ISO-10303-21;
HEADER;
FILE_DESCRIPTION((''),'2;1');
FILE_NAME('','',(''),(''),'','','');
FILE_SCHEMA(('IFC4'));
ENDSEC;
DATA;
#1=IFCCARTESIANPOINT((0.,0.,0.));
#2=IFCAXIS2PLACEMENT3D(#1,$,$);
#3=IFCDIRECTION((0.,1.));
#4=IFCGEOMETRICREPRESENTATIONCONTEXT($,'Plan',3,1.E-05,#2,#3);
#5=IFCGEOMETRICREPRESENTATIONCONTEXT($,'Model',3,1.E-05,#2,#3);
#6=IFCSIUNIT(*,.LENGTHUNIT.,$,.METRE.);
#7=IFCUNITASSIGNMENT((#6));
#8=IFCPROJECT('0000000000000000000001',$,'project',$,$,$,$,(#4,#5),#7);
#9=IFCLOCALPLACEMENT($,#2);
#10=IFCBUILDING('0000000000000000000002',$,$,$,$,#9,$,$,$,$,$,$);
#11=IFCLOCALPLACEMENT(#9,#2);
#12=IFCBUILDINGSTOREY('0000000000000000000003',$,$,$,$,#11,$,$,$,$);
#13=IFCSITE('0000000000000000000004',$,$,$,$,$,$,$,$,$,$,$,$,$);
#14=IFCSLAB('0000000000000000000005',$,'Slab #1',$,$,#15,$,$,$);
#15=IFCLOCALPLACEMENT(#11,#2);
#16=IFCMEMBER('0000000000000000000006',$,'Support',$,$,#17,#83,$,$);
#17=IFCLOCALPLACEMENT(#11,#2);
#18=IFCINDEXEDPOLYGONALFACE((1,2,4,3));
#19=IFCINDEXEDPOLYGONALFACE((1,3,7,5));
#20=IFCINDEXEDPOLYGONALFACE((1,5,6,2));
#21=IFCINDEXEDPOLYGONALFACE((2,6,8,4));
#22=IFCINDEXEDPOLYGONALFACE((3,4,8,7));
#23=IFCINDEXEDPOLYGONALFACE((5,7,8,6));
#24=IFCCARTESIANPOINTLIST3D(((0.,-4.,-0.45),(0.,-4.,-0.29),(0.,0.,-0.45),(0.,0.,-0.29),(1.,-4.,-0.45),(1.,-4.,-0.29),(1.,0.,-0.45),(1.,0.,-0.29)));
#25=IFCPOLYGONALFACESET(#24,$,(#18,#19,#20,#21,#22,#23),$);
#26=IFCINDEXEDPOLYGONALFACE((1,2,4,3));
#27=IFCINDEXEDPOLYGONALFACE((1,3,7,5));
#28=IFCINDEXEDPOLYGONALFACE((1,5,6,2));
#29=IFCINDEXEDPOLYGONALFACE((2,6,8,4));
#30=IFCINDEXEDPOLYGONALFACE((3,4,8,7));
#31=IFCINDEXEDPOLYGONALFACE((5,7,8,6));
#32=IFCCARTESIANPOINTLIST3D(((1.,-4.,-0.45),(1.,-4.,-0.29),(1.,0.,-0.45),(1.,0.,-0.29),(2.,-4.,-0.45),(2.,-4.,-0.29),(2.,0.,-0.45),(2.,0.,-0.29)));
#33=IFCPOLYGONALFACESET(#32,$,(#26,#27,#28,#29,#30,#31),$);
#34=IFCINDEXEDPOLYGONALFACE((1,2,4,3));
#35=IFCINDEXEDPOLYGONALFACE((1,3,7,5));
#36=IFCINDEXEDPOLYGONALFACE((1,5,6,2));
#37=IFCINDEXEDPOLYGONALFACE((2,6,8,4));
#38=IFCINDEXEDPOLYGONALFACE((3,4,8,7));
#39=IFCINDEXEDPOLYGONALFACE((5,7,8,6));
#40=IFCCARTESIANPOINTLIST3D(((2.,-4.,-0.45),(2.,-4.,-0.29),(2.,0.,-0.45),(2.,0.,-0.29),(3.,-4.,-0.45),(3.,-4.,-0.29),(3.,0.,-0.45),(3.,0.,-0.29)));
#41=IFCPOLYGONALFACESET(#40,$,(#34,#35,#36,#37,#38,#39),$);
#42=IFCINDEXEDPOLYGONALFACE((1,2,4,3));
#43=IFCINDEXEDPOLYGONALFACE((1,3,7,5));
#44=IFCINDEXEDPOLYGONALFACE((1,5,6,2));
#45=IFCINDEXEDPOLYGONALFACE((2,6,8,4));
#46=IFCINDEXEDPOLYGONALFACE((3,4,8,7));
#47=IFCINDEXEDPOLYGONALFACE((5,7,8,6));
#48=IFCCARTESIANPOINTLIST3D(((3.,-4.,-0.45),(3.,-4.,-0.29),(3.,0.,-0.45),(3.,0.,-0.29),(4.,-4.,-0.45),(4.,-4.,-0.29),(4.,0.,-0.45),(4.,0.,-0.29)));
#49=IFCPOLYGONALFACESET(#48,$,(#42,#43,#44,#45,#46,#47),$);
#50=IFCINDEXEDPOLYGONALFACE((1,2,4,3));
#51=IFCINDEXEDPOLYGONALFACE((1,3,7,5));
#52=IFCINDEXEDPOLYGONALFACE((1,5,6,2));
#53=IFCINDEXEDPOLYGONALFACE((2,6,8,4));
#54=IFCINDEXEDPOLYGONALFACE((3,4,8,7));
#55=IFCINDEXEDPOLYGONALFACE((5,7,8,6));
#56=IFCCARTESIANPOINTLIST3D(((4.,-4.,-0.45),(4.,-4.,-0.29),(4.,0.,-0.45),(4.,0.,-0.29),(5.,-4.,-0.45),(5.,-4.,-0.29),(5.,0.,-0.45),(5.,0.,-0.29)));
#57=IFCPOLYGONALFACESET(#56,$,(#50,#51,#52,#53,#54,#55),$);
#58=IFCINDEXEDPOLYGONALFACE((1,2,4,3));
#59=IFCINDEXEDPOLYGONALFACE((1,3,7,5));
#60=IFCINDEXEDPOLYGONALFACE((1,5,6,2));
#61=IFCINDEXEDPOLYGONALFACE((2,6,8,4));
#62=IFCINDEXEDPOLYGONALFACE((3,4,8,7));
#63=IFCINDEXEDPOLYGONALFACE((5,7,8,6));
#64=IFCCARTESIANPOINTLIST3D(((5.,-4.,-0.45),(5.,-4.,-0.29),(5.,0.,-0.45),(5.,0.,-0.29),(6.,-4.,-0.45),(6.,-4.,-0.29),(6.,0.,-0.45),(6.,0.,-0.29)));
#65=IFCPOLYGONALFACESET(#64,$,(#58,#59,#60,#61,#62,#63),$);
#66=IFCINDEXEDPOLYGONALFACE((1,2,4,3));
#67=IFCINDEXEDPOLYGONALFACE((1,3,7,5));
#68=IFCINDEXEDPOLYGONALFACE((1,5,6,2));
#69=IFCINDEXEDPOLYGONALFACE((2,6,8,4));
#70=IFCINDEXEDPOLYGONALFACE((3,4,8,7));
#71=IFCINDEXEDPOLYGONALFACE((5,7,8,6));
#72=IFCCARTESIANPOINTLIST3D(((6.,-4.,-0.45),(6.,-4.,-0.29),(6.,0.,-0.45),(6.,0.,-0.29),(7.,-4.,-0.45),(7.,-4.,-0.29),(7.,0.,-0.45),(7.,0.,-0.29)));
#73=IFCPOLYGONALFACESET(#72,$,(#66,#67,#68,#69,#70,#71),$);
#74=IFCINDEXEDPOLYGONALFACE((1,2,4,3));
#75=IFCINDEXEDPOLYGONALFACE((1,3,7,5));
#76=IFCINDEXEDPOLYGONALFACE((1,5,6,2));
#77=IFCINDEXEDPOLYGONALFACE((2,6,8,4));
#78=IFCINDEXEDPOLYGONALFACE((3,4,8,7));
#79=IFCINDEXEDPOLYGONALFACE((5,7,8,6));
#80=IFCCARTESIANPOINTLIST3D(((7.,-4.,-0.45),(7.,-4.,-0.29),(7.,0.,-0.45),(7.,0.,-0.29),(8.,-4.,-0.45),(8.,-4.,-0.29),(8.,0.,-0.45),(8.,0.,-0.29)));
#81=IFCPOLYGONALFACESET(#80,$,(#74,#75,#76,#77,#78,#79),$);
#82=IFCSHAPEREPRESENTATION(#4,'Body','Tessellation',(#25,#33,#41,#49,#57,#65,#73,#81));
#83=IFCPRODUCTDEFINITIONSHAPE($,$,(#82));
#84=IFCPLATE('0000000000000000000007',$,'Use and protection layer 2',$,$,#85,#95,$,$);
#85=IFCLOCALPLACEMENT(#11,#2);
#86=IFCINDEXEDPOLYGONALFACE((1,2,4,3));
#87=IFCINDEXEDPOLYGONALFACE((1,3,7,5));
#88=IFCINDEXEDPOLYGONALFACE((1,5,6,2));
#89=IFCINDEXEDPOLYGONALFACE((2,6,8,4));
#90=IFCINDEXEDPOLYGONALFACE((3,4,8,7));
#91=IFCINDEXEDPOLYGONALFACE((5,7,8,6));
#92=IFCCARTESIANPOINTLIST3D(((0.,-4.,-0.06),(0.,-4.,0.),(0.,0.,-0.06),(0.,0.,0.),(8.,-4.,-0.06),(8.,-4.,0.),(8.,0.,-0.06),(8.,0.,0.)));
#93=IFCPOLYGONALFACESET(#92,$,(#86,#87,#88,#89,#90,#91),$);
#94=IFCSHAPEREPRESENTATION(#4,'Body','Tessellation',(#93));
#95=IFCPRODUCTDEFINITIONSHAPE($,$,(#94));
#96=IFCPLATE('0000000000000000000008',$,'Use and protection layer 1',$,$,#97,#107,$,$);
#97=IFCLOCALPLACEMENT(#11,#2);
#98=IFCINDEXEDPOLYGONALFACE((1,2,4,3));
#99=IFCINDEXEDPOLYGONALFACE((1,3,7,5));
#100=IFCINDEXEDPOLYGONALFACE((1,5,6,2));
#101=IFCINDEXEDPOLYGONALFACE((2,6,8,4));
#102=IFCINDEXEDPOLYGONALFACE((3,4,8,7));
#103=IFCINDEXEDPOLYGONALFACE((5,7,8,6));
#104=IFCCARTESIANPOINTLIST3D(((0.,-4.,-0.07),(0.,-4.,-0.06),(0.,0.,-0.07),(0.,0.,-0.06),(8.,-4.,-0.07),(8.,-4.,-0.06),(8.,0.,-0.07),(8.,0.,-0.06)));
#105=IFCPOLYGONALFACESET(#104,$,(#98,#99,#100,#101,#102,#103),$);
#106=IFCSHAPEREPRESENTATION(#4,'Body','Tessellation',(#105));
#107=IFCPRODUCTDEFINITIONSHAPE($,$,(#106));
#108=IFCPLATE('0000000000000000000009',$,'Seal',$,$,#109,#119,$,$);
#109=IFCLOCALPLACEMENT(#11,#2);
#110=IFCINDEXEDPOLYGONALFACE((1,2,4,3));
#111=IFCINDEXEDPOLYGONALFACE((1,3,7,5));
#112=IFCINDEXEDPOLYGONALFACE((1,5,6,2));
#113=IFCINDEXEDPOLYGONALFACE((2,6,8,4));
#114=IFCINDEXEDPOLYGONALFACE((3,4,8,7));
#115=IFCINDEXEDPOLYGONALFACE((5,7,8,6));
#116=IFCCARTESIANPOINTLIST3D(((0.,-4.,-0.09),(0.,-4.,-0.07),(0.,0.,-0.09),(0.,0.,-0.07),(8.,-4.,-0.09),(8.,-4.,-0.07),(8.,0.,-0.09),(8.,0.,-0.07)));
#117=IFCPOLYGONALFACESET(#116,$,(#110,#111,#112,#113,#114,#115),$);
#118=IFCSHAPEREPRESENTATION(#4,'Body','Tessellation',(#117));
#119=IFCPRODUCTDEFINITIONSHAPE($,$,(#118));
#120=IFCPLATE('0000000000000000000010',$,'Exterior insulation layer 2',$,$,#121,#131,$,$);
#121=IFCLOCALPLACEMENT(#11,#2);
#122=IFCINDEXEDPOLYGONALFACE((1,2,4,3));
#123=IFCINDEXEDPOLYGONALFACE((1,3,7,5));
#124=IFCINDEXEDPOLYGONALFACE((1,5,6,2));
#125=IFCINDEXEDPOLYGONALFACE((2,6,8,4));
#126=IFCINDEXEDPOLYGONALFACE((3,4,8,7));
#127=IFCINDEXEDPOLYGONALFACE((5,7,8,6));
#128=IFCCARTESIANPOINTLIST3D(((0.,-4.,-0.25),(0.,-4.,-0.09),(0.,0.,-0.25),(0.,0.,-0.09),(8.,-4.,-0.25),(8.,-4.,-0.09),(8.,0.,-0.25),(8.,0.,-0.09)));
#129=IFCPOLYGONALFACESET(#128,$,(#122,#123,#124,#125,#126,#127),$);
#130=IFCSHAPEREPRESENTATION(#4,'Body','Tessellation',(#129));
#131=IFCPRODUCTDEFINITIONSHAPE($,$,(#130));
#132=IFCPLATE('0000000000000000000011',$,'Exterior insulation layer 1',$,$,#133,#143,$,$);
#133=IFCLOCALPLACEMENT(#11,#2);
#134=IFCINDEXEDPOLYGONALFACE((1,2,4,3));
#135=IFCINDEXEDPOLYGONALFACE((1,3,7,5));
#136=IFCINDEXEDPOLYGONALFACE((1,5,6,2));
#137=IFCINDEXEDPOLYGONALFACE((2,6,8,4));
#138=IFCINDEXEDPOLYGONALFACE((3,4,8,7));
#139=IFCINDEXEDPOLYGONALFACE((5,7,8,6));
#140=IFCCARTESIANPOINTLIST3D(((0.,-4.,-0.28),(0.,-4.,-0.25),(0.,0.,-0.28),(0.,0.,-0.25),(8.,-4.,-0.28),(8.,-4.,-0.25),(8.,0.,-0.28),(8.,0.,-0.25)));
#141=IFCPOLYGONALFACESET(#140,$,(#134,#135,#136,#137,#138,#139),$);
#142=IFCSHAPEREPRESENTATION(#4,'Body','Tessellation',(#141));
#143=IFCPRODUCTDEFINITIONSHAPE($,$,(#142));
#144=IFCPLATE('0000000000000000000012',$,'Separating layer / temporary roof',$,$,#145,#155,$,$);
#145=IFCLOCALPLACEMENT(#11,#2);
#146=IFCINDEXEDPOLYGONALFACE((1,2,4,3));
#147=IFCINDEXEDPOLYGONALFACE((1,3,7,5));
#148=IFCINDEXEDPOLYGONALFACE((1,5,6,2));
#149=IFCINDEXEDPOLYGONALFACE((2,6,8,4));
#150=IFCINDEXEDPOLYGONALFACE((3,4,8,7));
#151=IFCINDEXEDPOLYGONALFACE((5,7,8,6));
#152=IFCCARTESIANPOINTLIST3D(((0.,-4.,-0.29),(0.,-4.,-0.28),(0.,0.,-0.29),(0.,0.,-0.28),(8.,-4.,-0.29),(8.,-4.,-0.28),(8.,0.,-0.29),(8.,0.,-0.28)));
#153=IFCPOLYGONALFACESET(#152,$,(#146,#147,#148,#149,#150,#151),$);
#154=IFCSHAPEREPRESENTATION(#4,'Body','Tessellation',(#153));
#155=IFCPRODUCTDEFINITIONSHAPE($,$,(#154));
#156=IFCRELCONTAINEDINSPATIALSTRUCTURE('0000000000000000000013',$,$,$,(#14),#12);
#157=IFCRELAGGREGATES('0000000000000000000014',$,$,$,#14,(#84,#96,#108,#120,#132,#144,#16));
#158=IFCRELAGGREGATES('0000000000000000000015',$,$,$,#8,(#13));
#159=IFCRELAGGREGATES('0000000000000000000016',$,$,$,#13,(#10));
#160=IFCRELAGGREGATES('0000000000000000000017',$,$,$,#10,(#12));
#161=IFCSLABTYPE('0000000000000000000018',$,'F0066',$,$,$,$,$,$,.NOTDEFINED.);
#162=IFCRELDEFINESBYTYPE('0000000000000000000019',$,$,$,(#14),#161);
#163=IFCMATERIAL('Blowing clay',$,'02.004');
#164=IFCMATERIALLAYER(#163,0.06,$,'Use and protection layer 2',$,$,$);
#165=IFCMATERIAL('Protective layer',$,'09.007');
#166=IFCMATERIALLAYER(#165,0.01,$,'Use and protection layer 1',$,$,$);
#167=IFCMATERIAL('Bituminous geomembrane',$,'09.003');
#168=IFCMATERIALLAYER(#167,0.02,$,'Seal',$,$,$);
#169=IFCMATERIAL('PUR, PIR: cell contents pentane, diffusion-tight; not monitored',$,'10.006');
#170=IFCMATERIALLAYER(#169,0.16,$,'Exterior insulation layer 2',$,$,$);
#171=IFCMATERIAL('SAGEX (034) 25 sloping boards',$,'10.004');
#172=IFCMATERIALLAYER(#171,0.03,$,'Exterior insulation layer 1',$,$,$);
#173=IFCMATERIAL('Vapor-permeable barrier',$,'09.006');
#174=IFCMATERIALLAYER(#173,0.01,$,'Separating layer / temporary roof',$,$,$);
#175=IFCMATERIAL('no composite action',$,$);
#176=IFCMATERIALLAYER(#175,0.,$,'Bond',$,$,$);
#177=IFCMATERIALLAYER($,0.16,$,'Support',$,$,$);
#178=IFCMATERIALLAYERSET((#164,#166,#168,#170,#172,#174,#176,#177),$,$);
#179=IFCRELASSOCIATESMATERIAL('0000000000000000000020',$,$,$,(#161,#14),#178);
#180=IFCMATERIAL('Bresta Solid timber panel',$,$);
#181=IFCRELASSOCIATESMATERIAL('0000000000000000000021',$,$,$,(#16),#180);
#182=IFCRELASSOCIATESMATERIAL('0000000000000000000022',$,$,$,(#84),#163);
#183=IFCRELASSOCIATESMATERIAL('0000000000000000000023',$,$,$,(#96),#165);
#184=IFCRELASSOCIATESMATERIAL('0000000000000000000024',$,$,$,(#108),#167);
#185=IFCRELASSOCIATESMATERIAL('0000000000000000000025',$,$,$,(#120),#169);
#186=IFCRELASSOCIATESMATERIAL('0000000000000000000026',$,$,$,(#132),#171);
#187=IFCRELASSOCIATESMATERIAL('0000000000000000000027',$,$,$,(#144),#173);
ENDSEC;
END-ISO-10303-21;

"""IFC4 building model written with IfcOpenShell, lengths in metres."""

from ifc_helpers import new_model, si_unit, direction, frame, frame_2d, origin, origin_with_axes, place, context, project, spatial, rectangle, extrude, material, layer, layer_set, type_object, element, aggregate, save


model = new_model("IFC4")

# Units and contexts
plan_context = context("Plan", 3, precision=1e-05, world=origin(), true_north=direction((0.0, 1.0)))
model_context = context("Model", 3, precision=1e-05, world=origin(), true_north=direction((0.0, 1.0)))
ifc_project = project(units=[si_unit("LENGTHUNIT", "METRE")], contexts=[plan_context, model_context])

# Site, building, storey
site = spatial("IfcSite", under=ifc_project)
building_placement = place(None, origin())
building = spatial("IfcBuilding", under=site, at=building_placement)
storey_placement = place(building_placement, origin())
storey = spatial("IfcBuildingStorey", under=building, at=storey_placement)

# Slab, member, plates
ifc_material_1 = material(Name="Blowing clay", Category="02.004")
ifc_layer_1 = layer(ifc_material_1, 0.06, Name="Use and protection layer 2")
ifc_material_2 = material(Name="Protective layer", Category="09.007")
ifc_layer_2 = layer(ifc_material_2, 0.01, Name="Use and protection layer 1")
ifc_material_3 = material(Name="Bituminous geomembrane", Category="09.003")
ifc_layer_3 = layer(ifc_material_3, 0.02, Name="Seal")
ifc_material_4 = material(Name="PUR, PIR: cell contents pentane, diffusion-tight; not monitored", Category="10.006")
ifc_layer_4 = layer(ifc_material_4, 0.16, Name="Exterior insulation layer 2")
ifc_material_5 = material(Name="SAGEX (034) 25 sloping boards", Category="10.004")
ifc_layer_5 = layer(ifc_material_5, 0.03, Name="Exterior insulation layer 1")
ifc_material_6 = material(Name="Vapor-permeable barrier", Category="09.006")
ifc_layer_6 = layer(ifc_material_6, 0.01, Name="Separating layer / temporary roof")
ifc_material_7 = material(Name="no composite action")
ifc_layer_7 = layer(ifc_material_7, 0.0, Name="Bond")
ifc_layer_8 = layer(None, 0.16, Name="Support")
ifc_layer_set = layer_set([ifc_layer_1, ifc_layer_2, ifc_layer_3, ifc_layer_4, ifc_layer_5, ifc_layer_6, ifc_layer_7, ifc_layer_8])
slab_type = type_object("IfcSlabType", Name="F0066", PredefinedType="NOTDEFINED", material=ifc_layer_set)
slab_placement = place(None, frame((0.0, 0.0, 0.0), z_axis=(0.0, 0.0, -1.0), x_axis=(1.0, 0.0, 0.0)))
slab = element("IfcSlab", 1, at=slab_placement, inside=storey, type_object=slab_type, material=ifc_layer_set, Name="Slab #1")
ifc_material_8 = material(Name="Bresta Solid timber panel")
member_placement = place(slab_placement, origin())
member = element("IfcMember", 2, at=member_placement, material=ifc_material_8, Name="Support", context=plan_context, shape_type="SweptSolid", body=[
    extrude(rectangle(XDim=1.0, YDim=0.16, at=frame_2d((0.5, 0.08), x_axis=(1.0, 0.0))), frame((0.0, 4.0, 0.29), z_axis=(0.0, -1.0, 0.0), x_axis=(1.0, 0.0, 0.0)), (0.0, 0.0, 1.0), 4.0),
    extrude(rectangle(XDim=1.0, YDim=0.16, at=frame_2d((0.5, 0.08), x_axis=(1.0, 0.0))), frame((1.0, 4.0, 0.29), z_axis=(0.0, -1.0, 0.0), x_axis=(1.0, 0.0, 0.0)), (0.0, 0.0, 1.0), 4.0),
    extrude(rectangle(XDim=1.0, YDim=0.16, at=frame_2d((0.5, 0.08), x_axis=(1.0, 0.0))), frame((2.0, 4.0, 0.29), z_axis=(0.0, -1.0, 0.0), x_axis=(1.0, 0.0, 0.0)), (0.0, 0.0, 1.0), 4.0),
    extrude(rectangle(XDim=1.0, YDim=0.16, at=frame_2d((0.5, 0.08), x_axis=(1.0, 0.0))), frame((3.0, 4.0, 0.29), z_axis=(0.0, -1.0, 0.0), x_axis=(1.0, 0.0, 0.0)), (0.0, 0.0, 1.0), 4.0),
    extrude(rectangle(XDim=1.0, YDim=0.16, at=frame_2d((0.5, 0.08), x_axis=(1.0, 0.0))), frame((4.0, 4.0, 0.29), z_axis=(0.0, -1.0, 0.0), x_axis=(1.0, 0.0, 0.0)), (0.0, 0.0, 1.0), 4.0),
    extrude(rectangle(XDim=1.0, YDim=0.16, at=frame_2d((0.5, 0.08), x_axis=(1.0, 0.0))), frame((5.0, 4.0, 0.29), z_axis=(0.0, -1.0, 0.0), x_axis=(1.0, 0.0, 0.0)), (0.0, 0.0, 1.0), 4.0),
    extrude(rectangle(XDim=1.0, YDim=0.16, at=frame_2d((0.5, 0.08), x_axis=(1.0, 0.0))), frame((6.0, 4.0, 0.29), z_axis=(0.0, -1.0, 0.0), x_axis=(1.0, 0.0, 0.0)), (0.0, 0.0, 1.0), 4.0),
    extrude(rectangle(XDim=1.0, YDim=0.16, at=frame_2d((0.5, 0.08), x_axis=(1.0, 0.0))), frame((7.0, 4.0, 0.29), z_axis=(0.0, -1.0, 0.0), x_axis=(1.0, 0.0, 0.0)), (0.0, 0.0, 1.0), 4.0),
])
plate_1_placement = place(slab_placement, origin())
plate_1 = element("IfcPlate", 3, at=plate_1_placement, material=ifc_material_1, Name="Use and protection layer 2", context=plan_context, shape_type="SweptSolid", body=[
    extrude(rectangle(XDim=8.0, YDim=4.0, at=frame_2d((4.0, 2.0), x_axis=(1.0, 0.0))), origin_with_axes(), (0.0, 0.0, 1.0), 0.06),
])
plate_2_placement = place(slab_placement, origin())
plate_2 = element("IfcPlate", 4, at=plate_2_placement, material=ifc_material_2, Name="Use and protection layer 1", context=plan_context, shape_type="SweptSolid", body=[
    extrude(rectangle(XDim=8.0, YDim=4.0, at=frame_2d((4.0, 2.0), x_axis=(1.0, 0.0))), frame((0.0, 0.0, 0.06), z_axis=(0.0, 0.0, 1.0), x_axis=(1.0, 0.0, 0.0)), (0.0, 0.0, 1.0), 0.01),
])
plate_3_placement = place(slab_placement, origin())
plate_3 = element("IfcPlate", 5, at=plate_3_placement, material=ifc_material_3, Name="Seal", context=plan_context, shape_type="SweptSolid", body=[
    extrude(rectangle(XDim=8.0, YDim=4.0, at=frame_2d((4.0, 2.0), x_axis=(1.0, 0.0))), frame((0.0, 0.0, 0.07), z_axis=(0.0, 0.0, 1.0), x_axis=(1.0, 0.0, 0.0)), (0.0, 0.0, 1.0), 0.02),
])
plate_4_placement = place(slab_placement, origin())
plate_4 = element("IfcPlate", 6, at=plate_4_placement, material=ifc_material_4, Name="Exterior insulation layer 2", context=plan_context, shape_type="SweptSolid", body=[
    extrude(rectangle(XDim=8.0, YDim=4.0, at=frame_2d((4.0, 2.0), x_axis=(1.0, 0.0))), frame((0.0, 0.0, 0.09), z_axis=(0.0, 0.0, 1.0), x_axis=(1.0, 0.0, 0.0)), (0.0, 0.0, 1.0), 0.16),
])
plate_5_placement = place(slab_placement, origin())
plate_5 = element("IfcPlate", 7, at=plate_5_placement, material=ifc_material_5, Name="Exterior insulation layer 1", context=plan_context, shape_type="SweptSolid", body=[
    extrude(rectangle(XDim=8.0, YDim=4.0, at=frame_2d((4.0, 2.0), x_axis=(1.0, 0.0))), frame((0.0, 0.0, 0.25), z_axis=(0.0, 0.0, 1.0), x_axis=(1.0, 0.0, 0.0)), (0.0, 0.0, 1.0), 0.03),
])
plate_6_placement = place(slab_placement, origin())
plate_6 = element("IfcPlate", 8, at=plate_6_placement, material=ifc_material_6, Name="Separating layer / temporary roof", context=plan_context, shape_type="SweptSolid", body=[
    extrude(rectangle(XDim=8.0, YDim=4.0, at=frame_2d((4.0, 2.0), x_axis=(1.0, 0.0))), frame((0.0, 0.0, 0.28), z_axis=(0.0, 0.0, 1.0), x_axis=(1.0, 0.0, 0.0)), (0.0, 0.0, 1.0), 0.01),
])
aggregate(slab, [plate_1, plate_2, plate_3, plate_4, plate_5, plate_6, member])

save(model, "model.ifc")
